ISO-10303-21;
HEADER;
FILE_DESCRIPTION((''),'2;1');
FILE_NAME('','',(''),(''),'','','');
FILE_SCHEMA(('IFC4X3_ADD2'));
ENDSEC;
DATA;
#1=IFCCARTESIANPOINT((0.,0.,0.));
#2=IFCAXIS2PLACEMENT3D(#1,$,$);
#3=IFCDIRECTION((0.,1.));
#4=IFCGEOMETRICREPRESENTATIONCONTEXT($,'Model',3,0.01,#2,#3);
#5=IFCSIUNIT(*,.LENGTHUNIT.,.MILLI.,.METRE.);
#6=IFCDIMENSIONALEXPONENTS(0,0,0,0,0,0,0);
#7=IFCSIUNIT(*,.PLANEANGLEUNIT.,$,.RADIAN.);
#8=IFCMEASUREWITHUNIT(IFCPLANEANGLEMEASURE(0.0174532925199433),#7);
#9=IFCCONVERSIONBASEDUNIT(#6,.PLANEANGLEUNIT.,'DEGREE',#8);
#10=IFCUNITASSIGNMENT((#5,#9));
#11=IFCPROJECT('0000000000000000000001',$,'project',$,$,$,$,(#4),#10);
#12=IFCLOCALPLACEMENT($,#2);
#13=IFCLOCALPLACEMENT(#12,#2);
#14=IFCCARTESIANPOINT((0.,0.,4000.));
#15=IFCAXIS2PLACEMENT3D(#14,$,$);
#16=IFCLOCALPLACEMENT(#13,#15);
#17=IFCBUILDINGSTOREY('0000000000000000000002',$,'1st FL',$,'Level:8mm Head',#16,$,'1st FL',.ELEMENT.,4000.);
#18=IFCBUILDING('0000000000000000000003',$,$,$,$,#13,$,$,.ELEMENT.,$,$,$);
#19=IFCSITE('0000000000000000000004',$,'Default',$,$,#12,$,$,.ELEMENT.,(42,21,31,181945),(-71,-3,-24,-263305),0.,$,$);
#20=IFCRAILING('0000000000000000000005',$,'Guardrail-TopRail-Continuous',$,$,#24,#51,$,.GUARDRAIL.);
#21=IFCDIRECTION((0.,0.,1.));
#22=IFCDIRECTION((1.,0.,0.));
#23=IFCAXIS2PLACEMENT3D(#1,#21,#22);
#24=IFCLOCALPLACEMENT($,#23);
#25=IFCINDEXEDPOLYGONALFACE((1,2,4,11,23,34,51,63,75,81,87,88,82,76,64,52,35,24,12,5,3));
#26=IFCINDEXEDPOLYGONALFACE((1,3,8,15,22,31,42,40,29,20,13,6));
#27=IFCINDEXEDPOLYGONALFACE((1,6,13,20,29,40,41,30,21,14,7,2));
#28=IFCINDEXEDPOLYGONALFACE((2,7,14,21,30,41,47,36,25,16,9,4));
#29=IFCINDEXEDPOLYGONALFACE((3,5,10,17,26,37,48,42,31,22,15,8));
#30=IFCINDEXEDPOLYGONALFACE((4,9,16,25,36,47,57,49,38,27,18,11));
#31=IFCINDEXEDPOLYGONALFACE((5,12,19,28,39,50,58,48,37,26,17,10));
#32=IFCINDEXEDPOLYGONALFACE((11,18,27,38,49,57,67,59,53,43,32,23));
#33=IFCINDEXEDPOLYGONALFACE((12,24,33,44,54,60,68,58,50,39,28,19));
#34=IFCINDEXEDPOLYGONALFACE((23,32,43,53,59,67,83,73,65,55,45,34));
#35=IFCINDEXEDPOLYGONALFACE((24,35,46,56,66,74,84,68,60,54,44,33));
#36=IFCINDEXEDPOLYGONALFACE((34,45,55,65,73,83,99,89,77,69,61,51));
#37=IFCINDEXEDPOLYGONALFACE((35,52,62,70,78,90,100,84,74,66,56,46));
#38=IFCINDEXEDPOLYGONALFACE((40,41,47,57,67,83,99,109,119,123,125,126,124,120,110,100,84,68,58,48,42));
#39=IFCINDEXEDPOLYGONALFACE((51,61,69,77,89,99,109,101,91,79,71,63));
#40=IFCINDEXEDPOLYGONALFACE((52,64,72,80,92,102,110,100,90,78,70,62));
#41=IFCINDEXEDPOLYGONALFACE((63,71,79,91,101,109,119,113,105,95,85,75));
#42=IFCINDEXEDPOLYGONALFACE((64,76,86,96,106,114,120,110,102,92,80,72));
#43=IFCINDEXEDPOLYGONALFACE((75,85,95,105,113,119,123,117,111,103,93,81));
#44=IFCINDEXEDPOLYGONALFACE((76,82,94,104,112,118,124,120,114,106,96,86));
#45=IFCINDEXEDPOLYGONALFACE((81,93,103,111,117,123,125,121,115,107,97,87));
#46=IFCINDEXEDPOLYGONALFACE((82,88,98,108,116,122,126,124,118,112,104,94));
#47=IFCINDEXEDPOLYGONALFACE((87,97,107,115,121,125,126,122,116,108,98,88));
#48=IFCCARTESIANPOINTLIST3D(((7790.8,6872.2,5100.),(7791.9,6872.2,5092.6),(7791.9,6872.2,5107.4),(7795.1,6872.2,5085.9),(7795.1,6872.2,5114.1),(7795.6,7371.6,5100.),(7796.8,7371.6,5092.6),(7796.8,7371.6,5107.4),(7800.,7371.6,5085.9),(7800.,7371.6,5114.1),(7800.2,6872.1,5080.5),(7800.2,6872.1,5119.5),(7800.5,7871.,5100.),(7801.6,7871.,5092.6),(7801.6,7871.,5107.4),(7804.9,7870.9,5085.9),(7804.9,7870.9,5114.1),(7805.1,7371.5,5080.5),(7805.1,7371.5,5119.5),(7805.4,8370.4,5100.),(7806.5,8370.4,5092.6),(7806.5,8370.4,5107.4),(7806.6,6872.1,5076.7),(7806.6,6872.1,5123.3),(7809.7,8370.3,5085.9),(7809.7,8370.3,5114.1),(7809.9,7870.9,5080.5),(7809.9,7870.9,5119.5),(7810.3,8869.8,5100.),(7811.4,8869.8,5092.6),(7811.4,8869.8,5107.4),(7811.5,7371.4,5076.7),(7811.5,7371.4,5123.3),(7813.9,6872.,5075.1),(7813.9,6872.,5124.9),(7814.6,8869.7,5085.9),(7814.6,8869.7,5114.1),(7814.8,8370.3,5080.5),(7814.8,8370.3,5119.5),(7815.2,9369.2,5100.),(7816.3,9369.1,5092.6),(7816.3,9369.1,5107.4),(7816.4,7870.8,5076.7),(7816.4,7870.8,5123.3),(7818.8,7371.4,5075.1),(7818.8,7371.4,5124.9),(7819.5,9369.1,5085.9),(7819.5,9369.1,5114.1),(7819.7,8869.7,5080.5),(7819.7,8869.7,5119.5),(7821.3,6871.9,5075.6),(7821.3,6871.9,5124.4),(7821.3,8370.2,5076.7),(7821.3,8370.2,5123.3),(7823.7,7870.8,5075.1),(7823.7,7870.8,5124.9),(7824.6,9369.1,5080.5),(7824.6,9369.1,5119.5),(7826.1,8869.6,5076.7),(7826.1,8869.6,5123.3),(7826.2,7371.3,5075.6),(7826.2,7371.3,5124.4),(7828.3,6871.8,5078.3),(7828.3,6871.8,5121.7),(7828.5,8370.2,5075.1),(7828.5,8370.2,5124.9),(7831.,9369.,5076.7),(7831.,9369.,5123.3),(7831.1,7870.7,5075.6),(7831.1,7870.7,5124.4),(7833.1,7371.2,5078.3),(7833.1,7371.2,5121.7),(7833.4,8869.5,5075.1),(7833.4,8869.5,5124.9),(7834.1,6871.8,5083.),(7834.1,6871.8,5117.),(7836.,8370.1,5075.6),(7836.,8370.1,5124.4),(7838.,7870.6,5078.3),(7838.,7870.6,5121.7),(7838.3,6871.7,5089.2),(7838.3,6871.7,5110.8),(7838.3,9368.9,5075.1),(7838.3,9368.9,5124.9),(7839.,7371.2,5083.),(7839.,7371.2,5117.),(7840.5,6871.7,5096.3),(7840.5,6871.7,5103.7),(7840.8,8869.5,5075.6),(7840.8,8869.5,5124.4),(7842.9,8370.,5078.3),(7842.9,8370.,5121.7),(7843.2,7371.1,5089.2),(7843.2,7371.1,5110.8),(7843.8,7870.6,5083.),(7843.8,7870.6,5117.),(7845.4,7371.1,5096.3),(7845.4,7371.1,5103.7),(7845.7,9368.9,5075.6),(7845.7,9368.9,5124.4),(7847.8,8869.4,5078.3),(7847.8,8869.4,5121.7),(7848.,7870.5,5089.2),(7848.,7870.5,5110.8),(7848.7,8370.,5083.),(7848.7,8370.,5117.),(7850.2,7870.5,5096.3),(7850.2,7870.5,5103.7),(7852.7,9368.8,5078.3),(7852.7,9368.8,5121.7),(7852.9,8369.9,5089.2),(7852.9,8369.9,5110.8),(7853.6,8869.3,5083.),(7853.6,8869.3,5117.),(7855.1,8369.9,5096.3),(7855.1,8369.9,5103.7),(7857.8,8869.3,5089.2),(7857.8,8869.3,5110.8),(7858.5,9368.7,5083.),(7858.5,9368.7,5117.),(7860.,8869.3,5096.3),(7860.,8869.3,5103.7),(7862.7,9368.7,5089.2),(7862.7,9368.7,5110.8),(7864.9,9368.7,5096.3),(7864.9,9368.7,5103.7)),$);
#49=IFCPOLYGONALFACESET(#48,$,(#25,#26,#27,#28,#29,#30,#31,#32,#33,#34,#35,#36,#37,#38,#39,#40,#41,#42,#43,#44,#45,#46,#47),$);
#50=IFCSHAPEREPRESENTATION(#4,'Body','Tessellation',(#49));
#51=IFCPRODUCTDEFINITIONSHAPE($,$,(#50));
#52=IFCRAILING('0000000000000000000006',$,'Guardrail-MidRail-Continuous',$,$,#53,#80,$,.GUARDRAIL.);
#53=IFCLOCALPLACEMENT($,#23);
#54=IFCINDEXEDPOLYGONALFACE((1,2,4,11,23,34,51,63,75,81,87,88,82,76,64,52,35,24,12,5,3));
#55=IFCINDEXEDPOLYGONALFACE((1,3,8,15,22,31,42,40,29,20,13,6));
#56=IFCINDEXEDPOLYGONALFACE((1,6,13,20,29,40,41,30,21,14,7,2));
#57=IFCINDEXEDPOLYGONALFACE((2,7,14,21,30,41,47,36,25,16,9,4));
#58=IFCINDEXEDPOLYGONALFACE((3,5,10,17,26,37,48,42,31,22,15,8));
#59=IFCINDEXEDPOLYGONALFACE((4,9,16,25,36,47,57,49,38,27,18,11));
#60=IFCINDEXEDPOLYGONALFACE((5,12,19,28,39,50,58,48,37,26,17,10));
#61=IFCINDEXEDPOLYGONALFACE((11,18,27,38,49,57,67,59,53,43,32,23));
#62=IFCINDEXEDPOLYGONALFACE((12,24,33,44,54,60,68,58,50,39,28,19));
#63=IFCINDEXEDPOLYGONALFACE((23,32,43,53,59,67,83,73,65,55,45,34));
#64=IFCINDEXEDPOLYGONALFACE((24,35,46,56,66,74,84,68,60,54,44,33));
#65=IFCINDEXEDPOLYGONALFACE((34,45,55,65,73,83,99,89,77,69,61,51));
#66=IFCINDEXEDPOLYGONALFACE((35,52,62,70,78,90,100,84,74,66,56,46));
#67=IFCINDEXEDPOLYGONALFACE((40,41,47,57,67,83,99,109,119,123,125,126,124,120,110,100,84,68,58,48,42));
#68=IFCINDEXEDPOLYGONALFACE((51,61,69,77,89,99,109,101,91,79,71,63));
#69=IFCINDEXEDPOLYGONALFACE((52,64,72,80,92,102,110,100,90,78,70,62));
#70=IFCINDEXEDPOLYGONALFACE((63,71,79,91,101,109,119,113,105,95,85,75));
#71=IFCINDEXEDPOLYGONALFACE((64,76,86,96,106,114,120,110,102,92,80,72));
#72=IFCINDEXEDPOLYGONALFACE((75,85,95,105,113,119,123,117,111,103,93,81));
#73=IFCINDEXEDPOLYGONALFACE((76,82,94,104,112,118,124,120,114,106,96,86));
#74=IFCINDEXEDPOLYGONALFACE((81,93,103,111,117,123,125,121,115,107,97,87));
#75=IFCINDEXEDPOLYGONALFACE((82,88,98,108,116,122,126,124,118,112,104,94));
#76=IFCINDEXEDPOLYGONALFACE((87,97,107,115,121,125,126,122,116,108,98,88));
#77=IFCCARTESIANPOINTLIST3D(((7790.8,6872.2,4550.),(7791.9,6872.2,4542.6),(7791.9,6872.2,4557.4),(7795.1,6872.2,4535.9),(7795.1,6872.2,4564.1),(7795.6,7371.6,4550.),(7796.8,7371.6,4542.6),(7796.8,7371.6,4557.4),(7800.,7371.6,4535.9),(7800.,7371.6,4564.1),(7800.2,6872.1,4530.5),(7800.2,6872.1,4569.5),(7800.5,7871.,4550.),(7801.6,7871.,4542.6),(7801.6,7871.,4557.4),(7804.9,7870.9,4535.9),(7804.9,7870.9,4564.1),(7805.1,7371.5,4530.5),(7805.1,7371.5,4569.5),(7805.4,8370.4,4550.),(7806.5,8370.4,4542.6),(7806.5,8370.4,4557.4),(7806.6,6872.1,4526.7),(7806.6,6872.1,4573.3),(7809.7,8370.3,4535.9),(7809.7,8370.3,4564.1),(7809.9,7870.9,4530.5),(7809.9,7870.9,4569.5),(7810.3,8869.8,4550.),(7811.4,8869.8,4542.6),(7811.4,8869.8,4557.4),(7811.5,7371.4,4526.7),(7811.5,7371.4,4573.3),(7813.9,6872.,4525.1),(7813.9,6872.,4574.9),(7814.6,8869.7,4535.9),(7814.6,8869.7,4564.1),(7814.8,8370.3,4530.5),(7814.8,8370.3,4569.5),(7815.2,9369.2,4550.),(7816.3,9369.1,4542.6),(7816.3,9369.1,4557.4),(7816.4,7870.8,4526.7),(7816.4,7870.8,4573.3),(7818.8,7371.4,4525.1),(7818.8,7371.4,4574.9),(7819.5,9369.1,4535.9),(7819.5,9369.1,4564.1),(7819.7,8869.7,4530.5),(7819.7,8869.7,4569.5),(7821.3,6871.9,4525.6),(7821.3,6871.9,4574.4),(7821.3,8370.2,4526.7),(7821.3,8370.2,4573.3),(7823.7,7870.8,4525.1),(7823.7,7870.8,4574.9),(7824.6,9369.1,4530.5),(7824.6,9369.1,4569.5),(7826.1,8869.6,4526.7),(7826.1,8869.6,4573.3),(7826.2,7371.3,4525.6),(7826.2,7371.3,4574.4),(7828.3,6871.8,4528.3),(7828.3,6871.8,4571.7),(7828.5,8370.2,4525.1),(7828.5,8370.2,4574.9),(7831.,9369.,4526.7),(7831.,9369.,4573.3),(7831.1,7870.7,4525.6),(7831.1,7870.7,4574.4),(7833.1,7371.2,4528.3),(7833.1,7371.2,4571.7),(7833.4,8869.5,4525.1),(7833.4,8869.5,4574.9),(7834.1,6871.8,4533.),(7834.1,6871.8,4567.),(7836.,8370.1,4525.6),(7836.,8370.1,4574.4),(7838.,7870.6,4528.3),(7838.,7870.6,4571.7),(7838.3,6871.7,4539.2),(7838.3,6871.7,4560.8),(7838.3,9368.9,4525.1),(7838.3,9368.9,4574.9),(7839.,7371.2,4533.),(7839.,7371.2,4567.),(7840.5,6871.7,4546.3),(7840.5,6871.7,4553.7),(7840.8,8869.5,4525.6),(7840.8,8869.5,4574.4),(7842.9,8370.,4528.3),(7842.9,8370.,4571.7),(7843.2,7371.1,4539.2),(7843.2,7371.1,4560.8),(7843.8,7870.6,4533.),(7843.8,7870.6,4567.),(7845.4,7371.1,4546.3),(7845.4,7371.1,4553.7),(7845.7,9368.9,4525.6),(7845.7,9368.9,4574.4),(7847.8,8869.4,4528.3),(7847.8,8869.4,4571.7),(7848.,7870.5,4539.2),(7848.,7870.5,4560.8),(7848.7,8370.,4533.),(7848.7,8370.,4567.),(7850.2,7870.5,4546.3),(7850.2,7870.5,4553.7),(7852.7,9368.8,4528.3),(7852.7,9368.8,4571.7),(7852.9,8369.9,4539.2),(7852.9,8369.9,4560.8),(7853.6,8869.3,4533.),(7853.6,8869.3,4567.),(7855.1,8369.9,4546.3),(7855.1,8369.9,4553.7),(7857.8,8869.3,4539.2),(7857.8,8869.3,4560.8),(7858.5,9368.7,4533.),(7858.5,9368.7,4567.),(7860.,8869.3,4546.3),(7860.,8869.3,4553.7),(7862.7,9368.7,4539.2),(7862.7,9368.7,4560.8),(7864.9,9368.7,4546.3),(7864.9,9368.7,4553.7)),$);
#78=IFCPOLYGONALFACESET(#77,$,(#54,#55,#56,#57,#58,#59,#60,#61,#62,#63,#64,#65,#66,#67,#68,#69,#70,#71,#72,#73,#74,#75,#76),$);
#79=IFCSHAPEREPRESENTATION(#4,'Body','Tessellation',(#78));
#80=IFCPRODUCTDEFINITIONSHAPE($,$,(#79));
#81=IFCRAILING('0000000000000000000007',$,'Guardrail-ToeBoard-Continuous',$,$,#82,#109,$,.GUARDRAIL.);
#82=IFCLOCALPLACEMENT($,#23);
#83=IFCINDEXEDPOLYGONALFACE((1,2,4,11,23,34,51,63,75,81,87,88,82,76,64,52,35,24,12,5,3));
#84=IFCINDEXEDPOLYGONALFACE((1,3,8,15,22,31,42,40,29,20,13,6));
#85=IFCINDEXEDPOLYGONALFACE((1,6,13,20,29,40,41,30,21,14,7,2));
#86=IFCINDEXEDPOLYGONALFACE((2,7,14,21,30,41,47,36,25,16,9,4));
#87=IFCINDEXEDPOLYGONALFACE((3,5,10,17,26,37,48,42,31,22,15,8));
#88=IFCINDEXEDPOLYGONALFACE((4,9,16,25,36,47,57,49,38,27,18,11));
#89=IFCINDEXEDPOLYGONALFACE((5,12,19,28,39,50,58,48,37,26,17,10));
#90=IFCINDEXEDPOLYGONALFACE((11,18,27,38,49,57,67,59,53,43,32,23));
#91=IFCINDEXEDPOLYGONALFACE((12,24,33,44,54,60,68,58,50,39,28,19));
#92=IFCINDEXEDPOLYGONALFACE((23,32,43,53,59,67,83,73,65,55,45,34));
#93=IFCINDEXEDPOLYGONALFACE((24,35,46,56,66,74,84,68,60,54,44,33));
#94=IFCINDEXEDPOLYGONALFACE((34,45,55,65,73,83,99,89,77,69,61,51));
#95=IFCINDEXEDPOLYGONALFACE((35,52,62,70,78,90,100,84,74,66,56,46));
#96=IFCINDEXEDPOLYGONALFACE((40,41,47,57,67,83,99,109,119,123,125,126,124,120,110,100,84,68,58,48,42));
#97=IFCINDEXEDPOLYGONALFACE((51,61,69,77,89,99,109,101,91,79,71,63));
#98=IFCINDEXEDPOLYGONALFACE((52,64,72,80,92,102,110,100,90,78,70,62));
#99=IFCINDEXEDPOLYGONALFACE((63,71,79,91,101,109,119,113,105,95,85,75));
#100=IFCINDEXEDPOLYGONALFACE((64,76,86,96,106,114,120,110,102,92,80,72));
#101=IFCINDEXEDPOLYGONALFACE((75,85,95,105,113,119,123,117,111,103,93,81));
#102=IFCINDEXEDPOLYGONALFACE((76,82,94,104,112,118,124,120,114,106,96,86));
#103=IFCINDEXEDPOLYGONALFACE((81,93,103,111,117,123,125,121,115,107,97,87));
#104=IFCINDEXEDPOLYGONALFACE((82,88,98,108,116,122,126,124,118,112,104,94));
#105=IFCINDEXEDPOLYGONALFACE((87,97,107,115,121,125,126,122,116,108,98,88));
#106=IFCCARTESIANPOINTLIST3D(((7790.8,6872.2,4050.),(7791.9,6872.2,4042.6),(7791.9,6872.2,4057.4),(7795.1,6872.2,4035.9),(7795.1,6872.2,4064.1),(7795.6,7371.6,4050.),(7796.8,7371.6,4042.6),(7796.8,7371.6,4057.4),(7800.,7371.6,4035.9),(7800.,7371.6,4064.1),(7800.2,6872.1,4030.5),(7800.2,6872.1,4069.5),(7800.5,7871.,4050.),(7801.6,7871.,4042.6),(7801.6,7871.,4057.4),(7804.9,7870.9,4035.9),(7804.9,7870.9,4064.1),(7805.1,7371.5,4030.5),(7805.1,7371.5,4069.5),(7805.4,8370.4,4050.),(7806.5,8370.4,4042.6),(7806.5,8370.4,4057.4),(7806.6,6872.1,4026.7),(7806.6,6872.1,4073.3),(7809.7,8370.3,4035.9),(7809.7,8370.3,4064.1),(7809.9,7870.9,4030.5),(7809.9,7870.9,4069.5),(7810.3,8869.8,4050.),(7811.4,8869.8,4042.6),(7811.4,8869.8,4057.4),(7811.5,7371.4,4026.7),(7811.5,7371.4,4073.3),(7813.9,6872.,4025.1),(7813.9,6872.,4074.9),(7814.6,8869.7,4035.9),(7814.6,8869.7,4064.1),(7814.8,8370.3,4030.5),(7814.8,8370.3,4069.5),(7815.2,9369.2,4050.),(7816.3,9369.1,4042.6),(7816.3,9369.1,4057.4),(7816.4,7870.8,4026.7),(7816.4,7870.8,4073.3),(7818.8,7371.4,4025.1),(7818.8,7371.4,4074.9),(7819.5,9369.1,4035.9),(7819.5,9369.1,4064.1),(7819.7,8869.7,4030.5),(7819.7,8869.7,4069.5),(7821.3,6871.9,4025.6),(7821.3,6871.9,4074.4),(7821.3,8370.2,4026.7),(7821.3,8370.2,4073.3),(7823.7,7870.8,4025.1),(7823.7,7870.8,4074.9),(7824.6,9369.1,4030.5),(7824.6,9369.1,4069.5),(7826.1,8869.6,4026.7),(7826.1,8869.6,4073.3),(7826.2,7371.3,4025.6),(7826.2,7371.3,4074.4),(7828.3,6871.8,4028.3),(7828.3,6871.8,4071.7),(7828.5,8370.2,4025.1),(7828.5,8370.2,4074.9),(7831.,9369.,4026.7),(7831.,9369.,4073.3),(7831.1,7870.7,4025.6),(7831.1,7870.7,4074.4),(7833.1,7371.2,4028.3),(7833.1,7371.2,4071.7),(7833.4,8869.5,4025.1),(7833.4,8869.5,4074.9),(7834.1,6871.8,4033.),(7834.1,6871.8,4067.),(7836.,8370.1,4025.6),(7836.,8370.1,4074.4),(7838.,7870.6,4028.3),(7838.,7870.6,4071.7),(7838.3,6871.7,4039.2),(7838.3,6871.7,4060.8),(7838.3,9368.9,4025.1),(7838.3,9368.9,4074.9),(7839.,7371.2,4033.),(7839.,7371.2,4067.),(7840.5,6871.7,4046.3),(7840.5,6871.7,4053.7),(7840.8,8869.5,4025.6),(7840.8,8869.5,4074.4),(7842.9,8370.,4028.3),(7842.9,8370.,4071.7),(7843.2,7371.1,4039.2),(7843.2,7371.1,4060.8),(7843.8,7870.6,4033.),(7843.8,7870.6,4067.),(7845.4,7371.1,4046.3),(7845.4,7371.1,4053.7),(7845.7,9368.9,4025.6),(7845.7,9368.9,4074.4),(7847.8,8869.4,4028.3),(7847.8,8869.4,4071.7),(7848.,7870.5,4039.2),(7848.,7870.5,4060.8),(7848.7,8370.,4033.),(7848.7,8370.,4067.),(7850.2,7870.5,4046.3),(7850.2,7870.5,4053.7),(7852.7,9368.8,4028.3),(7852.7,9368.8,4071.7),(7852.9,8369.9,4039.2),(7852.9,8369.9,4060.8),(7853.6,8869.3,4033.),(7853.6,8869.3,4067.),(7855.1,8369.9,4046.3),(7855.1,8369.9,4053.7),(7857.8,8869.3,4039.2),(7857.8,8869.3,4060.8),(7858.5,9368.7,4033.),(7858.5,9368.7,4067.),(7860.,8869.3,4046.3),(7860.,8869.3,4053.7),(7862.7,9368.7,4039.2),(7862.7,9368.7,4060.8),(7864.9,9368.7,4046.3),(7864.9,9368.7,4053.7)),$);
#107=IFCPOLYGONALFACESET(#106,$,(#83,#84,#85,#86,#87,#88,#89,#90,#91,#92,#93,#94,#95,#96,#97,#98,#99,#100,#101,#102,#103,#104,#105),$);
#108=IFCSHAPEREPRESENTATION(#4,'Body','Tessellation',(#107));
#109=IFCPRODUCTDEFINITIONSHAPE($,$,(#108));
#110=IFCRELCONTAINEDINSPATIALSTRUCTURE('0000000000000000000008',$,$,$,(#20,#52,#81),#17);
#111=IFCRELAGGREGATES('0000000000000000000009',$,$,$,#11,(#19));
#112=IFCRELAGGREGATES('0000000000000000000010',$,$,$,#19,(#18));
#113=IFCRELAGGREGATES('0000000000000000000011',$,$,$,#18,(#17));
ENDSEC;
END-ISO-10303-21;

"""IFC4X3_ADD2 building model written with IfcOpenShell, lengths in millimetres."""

from ifc_helpers import new_model, entity, si_unit, converted_unit, direction, frame, origin, origin_with_axes, place, context, project, spatial, element, save


model = new_model("IFC4X3_ADD2")

# Units and contexts
model_context = context("Model", 3, precision=0.01, world=origin(), true_north=direction((0.0, 1.0)))
ifc_project = project(units=[si_unit("LENGTHUNIT", "METRE", prefix="MILLI"), converted_unit("PLANEANGLEUNIT", "DEGREE", entity("IfcPlaneAngleMeasure", 0.0174532925199433), si_unit("PLANEANGLEUNIT", "RADIAN"), dimensions=[0, 0, 0, 0, 0, 0, 0])], contexts=[model_context])

# Site, building, storey
site_placement = place(None, origin())
site = spatial("IfcSite", under=ifc_project, at=site_placement, Name="Default", CompositionType="ELEMENT", RefLatitude=(42, 21, 31, 181945), RefLongitude=(-71, -3, -24, -263305), RefElevation=0.0)
building_placement = place(site_placement, origin())
building = spatial("IfcBuilding", under=site, at=building_placement, CompositionType="ELEMENT")
storey_placement = place(building_placement, frame((0.0, 0.0, 4000.0)))
storey = spatial("IfcBuildingStorey", under=building, at=storey_placement, Name="1st FL", ObjectType="Level:8mm Head", LongName="1st FL", CompositionType="ELEMENT", Elevation=4000.0)

# Railings
railing_1_placement = place(None, origin_with_axes())
element("IfcRailing", 1, at=railing_1_placement, inside=storey, Name="Guardrail-TopRail-Continuous", PredefinedType="GUARDRAIL", context=model_context, shape_type="SweptSolid", body=[
    entity("IfcSweptDiskSolid", entity("IfcPolyline", [entity("IfcCartesianPoint", [7840.2, 9368.9, 5100.0]), entity("IfcCartesianPoint", [7835.3, 8869.5, 5100.0]), entity("IfcCartesianPoint", [7830.4, 8370.1, 5100.0]), entity("IfcCartesianPoint", [7825.5, 7870.7, 5100.0]), entity("IfcCartesianPoint", [7820.6, 7371.4, 5100.0]), entity("IfcCartesianPoint", [7815.8, 6872.0, 5100.0])]), 25.0),
])
railing_2_placement = place(None, origin_with_axes())
element("IfcRailing", 2, at=railing_2_placement, inside=storey, Name="Guardrail-MidRail-Continuous", PredefinedType="GUARDRAIL", context=model_context, shape_type="SweptSolid", body=[
    entity("IfcSweptDiskSolid", entity("IfcPolyline", [entity("IfcCartesianPoint", [7840.2, 9368.9, 4550.0]), entity("IfcCartesianPoint", [7835.3, 8869.5, 4550.0]), entity("IfcCartesianPoint", [7830.4, 8370.1, 4550.0]), entity("IfcCartesianPoint", [7825.5, 7870.7, 4550.0]), entity("IfcCartesianPoint", [7820.6, 7371.4, 4550.0]), entity("IfcCartesianPoint", [7815.8, 6872.0, 4550.0])]), 25.0),
])
railing_3_placement = place(None, origin_with_axes())
element("IfcRailing", 3, at=railing_3_placement, inside=storey, Name="Guardrail-ToeBoard-Continuous", PredefinedType="GUARDRAIL", context=model_context, shape_type="SweptSolid", body=[
    entity("IfcSweptDiskSolid", entity("IfcPolyline", [entity("IfcCartesianPoint", [7840.2, 9368.9, 4050.0]), entity("IfcCartesianPoint", [7835.3, 8869.5, 4050.0]), entity("IfcCartesianPoint", [7830.4, 8370.1, 4050.0]), entity("IfcCartesianPoint", [7825.5, 7870.7, 4050.0]), entity("IfcCartesianPoint", [7820.6, 7371.4, 4050.0]), entity("IfcCartesianPoint", [7815.8, 6872.0, 4050.0])]), 25.0),
])

save(model, "model.ifc")
